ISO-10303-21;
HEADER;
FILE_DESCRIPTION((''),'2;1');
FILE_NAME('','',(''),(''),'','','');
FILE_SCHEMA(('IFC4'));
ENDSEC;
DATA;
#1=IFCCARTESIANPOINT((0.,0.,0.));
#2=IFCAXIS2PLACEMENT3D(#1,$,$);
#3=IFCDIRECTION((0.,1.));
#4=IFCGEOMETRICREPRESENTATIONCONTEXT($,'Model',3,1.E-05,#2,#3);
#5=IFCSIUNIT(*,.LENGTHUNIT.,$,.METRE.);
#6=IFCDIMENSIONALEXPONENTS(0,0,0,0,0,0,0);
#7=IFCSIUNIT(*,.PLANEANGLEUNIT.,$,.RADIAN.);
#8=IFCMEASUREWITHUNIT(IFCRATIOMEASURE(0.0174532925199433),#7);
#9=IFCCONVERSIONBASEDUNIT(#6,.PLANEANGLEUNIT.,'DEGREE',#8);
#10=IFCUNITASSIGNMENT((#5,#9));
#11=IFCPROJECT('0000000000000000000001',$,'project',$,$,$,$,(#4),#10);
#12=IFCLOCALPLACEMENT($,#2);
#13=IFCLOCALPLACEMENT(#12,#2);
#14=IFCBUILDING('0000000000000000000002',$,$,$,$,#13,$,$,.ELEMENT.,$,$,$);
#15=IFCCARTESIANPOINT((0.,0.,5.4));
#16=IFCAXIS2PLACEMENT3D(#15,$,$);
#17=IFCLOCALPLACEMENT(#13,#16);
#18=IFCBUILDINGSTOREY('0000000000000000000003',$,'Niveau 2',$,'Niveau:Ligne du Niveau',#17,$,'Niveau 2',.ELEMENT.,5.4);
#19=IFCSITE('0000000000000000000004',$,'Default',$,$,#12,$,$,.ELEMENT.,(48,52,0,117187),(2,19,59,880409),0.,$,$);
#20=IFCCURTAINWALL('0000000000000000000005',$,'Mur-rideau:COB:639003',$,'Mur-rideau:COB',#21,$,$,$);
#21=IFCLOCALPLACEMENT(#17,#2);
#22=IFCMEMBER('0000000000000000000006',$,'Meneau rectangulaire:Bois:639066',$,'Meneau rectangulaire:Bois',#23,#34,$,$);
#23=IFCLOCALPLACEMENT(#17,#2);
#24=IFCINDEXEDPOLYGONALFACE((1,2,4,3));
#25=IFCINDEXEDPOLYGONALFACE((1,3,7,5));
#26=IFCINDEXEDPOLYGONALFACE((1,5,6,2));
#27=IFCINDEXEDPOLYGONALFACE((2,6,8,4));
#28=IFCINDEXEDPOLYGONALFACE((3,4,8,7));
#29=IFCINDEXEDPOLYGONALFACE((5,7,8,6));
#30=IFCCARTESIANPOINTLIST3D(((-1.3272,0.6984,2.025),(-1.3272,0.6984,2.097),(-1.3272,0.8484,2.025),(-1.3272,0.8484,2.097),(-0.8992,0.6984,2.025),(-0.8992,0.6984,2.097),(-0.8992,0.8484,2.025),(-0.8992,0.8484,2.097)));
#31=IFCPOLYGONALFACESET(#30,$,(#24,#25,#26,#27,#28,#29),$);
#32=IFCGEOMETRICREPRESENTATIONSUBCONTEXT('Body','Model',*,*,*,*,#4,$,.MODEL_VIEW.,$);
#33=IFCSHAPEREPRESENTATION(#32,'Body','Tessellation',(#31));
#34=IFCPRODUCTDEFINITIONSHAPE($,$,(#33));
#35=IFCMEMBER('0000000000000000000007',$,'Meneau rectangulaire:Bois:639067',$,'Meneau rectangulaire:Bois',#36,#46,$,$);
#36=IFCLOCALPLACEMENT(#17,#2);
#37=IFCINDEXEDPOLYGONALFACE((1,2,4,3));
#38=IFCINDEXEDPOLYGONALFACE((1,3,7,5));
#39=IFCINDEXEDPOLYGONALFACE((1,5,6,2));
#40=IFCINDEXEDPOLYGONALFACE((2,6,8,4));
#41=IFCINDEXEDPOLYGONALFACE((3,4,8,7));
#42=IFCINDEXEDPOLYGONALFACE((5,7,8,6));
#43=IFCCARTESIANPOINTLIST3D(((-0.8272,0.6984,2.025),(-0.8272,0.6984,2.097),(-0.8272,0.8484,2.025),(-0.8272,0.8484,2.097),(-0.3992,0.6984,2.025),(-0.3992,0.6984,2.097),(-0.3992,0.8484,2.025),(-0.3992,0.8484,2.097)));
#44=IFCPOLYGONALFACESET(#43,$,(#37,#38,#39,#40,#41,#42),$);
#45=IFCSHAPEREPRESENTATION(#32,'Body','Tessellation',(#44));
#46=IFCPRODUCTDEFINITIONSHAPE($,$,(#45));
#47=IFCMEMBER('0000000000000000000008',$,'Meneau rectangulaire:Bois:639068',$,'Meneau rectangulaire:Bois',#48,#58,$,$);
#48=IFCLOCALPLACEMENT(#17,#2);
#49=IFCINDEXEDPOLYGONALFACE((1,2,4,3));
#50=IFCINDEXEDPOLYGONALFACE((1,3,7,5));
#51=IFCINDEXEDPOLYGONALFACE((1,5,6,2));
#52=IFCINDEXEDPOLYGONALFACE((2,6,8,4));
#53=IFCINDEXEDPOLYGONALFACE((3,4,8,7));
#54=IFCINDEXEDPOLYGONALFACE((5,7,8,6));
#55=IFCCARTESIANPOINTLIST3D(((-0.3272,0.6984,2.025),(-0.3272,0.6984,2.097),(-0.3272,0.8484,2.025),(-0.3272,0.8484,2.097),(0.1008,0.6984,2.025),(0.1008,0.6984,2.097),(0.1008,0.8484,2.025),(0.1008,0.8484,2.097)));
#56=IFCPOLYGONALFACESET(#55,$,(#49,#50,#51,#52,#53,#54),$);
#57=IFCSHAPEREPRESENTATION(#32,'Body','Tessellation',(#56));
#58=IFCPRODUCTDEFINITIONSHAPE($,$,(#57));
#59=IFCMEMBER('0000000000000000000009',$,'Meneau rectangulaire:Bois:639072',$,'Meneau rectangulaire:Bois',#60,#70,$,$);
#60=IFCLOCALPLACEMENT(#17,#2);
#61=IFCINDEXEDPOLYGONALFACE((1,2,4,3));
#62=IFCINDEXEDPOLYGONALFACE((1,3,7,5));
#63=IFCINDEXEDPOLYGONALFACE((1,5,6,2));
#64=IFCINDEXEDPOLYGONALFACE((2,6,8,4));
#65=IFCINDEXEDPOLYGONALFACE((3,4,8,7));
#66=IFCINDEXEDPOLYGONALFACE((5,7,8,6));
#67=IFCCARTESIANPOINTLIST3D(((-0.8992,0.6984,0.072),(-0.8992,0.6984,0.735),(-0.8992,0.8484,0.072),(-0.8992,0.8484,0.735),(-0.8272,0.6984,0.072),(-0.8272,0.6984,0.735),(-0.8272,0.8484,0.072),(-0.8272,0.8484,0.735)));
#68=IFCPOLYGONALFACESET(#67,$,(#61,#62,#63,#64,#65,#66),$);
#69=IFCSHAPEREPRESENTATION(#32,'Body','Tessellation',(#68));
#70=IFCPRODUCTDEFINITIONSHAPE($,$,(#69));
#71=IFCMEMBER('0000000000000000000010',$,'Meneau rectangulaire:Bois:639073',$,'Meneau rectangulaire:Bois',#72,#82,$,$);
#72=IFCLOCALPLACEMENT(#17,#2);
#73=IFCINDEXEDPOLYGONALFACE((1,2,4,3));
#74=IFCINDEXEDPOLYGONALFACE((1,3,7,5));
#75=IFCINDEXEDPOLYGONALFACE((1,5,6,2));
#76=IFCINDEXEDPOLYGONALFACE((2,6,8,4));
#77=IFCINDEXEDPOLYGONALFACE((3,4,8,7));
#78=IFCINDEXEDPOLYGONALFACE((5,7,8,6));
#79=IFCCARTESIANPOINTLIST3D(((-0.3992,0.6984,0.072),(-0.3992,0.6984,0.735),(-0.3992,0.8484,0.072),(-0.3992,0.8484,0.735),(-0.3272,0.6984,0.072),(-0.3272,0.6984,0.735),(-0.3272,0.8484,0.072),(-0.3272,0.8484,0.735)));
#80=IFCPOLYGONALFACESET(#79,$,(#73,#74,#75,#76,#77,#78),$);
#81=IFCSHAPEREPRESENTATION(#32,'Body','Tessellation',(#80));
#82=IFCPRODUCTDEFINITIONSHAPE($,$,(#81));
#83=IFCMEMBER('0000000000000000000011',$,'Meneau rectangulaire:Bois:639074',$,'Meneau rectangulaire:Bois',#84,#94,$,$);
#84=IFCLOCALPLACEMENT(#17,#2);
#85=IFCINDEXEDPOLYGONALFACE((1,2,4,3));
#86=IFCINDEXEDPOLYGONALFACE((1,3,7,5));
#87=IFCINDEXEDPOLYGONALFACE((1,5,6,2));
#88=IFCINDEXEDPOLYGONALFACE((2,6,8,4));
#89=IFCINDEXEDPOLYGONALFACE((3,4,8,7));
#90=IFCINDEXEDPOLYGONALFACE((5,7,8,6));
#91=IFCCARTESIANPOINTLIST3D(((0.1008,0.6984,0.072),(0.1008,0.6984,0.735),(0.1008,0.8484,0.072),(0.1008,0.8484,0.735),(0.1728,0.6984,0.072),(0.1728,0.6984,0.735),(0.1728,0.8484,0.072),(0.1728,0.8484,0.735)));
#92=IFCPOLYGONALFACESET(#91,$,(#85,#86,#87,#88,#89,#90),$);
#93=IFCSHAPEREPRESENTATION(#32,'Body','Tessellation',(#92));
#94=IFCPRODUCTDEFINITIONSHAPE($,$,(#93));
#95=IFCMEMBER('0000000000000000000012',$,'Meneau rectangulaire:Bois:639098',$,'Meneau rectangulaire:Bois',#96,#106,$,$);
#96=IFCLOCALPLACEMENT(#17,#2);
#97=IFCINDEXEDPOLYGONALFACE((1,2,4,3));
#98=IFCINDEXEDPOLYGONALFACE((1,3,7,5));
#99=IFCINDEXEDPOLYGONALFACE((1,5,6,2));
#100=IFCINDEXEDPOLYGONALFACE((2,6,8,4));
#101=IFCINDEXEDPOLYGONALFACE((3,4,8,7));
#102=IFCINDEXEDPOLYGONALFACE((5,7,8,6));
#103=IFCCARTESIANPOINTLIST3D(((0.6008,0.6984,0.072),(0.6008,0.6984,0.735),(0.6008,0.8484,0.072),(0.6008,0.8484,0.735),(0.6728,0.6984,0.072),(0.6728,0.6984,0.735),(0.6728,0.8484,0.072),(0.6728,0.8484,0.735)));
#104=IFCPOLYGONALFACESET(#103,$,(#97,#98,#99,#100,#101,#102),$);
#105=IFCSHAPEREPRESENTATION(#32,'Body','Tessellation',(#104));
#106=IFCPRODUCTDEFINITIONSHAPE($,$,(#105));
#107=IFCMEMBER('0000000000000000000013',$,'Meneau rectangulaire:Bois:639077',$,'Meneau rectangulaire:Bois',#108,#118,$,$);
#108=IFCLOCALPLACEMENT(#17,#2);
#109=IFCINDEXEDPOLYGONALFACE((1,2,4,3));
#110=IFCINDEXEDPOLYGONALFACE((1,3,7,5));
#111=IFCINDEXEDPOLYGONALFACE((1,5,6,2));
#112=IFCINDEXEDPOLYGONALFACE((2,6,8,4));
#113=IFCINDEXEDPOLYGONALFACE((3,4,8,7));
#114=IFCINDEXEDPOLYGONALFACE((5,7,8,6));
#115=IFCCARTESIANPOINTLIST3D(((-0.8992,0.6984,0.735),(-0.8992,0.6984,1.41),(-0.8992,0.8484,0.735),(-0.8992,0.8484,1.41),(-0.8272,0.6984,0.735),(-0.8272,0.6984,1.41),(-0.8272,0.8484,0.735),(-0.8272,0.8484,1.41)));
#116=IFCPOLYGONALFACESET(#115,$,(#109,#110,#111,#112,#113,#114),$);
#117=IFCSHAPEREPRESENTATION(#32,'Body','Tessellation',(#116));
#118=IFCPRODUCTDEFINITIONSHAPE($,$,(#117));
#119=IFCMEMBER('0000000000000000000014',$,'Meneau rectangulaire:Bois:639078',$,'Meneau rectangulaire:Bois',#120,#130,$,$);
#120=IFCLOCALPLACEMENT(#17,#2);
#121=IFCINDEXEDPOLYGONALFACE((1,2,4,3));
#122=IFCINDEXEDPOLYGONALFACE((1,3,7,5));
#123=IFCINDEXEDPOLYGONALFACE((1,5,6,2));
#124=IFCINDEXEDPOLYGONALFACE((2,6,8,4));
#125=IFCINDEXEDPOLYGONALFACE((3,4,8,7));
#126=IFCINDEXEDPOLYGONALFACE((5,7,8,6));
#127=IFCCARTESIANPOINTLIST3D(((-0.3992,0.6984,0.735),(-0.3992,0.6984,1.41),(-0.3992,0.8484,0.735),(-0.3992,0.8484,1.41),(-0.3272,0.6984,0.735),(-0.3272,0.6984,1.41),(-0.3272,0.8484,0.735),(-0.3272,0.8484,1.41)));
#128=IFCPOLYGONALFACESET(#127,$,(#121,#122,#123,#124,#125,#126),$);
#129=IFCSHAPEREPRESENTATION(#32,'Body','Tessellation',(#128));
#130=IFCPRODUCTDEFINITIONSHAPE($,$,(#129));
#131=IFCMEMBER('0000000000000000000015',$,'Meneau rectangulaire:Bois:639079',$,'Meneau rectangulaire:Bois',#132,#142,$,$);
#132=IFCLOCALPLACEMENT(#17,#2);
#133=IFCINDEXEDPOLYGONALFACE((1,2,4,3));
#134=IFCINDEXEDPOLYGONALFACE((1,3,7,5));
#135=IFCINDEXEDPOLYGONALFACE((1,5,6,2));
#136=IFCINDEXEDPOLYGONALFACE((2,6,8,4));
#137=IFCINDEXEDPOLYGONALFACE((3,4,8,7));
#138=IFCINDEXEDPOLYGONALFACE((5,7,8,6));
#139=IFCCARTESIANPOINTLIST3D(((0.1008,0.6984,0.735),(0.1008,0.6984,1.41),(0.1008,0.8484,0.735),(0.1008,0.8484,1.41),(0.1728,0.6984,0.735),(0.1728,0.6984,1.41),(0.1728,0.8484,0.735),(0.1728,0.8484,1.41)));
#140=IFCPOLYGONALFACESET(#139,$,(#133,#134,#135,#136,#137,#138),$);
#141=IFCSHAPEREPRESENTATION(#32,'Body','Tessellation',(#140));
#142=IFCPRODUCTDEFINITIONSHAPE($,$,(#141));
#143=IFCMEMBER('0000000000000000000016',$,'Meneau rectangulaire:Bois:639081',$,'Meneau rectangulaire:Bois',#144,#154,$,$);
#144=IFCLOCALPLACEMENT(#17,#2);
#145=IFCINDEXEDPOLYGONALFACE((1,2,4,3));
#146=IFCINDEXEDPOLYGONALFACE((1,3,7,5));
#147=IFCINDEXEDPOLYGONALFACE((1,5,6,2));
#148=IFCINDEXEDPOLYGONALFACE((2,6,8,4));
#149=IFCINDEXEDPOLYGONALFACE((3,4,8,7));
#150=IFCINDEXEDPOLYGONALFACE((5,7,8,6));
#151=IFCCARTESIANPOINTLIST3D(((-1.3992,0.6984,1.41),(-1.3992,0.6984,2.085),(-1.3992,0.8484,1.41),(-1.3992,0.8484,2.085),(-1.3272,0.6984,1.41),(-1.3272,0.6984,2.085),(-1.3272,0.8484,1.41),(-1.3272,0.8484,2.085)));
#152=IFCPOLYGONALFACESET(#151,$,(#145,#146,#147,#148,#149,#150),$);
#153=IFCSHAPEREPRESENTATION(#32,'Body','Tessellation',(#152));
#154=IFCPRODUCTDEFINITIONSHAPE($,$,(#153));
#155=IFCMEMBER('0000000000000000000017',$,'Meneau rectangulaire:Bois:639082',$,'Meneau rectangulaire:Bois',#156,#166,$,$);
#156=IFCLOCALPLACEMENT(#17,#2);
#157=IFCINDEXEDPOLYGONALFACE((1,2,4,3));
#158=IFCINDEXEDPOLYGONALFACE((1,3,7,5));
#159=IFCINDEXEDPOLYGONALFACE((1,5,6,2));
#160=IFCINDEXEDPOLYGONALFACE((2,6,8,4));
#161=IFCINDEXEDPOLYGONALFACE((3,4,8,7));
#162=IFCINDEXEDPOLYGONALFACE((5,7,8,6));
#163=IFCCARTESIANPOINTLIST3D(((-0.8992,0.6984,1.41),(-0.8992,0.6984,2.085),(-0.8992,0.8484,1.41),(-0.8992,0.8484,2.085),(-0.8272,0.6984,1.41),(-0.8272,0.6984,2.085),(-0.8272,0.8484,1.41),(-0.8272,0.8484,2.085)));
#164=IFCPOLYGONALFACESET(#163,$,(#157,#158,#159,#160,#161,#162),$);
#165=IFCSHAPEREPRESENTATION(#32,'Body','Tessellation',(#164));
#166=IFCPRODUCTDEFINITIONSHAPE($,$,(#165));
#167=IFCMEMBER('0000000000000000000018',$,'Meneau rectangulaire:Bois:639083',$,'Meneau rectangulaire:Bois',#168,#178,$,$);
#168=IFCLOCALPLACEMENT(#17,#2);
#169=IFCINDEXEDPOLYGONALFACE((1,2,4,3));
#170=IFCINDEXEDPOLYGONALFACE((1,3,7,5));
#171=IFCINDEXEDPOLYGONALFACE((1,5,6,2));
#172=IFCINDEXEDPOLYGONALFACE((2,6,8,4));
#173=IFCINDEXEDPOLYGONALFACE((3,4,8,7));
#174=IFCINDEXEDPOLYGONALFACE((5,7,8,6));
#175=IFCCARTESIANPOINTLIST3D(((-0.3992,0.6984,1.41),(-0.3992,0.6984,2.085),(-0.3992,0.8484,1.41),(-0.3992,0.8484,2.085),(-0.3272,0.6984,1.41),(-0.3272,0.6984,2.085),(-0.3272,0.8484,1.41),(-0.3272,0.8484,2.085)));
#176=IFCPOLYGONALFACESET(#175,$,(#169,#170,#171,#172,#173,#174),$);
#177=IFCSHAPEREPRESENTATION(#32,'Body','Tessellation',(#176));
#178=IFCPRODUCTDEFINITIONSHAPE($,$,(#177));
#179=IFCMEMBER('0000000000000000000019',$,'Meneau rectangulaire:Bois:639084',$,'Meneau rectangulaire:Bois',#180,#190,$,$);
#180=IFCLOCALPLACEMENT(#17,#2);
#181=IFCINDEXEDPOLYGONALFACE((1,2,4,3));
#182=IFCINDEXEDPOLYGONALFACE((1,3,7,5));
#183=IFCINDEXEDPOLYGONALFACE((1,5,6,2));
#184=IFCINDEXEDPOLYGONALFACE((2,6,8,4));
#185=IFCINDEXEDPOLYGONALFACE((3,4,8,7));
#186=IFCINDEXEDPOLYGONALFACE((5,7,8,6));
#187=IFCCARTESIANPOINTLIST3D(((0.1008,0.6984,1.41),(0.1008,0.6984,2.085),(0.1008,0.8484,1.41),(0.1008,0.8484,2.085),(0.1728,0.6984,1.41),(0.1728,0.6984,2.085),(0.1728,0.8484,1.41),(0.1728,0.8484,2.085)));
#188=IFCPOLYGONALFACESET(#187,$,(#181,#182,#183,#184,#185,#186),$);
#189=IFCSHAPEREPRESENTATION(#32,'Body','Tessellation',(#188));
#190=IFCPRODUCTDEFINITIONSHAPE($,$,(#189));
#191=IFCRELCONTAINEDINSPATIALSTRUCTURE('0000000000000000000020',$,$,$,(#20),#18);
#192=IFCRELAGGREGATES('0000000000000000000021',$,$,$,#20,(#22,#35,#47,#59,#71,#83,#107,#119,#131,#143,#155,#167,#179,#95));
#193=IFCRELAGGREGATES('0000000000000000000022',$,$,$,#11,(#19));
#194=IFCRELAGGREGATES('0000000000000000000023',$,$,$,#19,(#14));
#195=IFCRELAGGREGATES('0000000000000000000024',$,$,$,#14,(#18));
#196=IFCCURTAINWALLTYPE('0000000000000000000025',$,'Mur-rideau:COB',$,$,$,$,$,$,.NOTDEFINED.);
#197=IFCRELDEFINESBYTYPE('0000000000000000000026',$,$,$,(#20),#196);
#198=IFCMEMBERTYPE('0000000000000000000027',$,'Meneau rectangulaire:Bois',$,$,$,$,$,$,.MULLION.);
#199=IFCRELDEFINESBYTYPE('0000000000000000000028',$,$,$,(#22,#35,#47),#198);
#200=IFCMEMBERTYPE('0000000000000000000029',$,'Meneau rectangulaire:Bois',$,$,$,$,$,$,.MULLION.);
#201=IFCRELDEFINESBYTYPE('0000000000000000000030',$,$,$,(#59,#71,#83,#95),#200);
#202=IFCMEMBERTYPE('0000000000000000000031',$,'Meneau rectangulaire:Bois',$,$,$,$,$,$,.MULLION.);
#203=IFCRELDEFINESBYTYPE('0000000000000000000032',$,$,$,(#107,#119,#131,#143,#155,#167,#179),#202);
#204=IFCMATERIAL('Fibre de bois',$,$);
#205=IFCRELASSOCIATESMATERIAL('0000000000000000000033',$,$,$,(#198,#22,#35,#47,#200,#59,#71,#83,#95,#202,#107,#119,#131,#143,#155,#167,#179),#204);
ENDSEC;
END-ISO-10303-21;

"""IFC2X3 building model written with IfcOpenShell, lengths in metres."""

from ifc_helpers import new_model, entity, si_unit, converted_unit, direction, frame, origin, origin_2d_with_axis, place, context, subcontext, project, spatial, rectangle, extrude, source, transform, mapped, material, type_object, type_shapes, element, aggregate, save


model = new_model("IFC2X3")

# Units and contexts
model_context = context("Model", 3, precision=1e-05, world=origin(), true_north=direction((0.0, 1.0)))
body_context = subcontext(model_context, "Body", "Model", "MODEL_VIEW")
ifc_project = project(units=[si_unit("LENGTHUNIT", "METRE"), converted_unit("PLANEANGLEUNIT", "DEGREE", entity("IfcRatioMeasure", 0.0174532925199433), si_unit("PLANEANGLEUNIT", "RADIAN"), dimensions=[0, 0, 0, 0, 0, 0, 0])], contexts=[model_context])

# Site, building, storey
site_placement = place(None, origin())
site = spatial("IfcSite", under=ifc_project, at=site_placement, Name="Default", CompositionType="ELEMENT", RefLatitude=(48, 52, 0, 117187), RefLongitude=(2, 19, 59, 880409), RefElevation=0.0)
building_placement = place(site_placement, origin())
building = spatial("IfcBuilding", under=site, at=building_placement, CompositionType="ELEMENT")
storey_placement = place(building_placement, frame((0.0, 0.0, 5.4)))
storey = spatial("IfcBuildingStorey", under=building, at=storey_placement, Name="Niveau 2", ObjectType="Niveau:Ligne du Niveau", LongName="Niveau 2", CompositionType="ELEMENT", Elevation=5.4)

# Curtain wall, members
curtain_wall_type_1 = type_object("IfcCurtainWallType", Name="Mur-rideau:COB", PredefinedType="NOTDEFINED")
curtain_wall_1_placement = place(storey_placement, frame((0.0, 0.0, -5.4)))
curtain_wall_1 = element("IfcCurtainWall", 1, at=curtain_wall_1_placement, inside=storey, type_object=curtain_wall_type_1, Name="Mur-rideau:COB:639003", ObjectType="Mur-rideau:COB")
ifc_material_1 = material(Name="Fibre de bois")
member_type_1 = type_object("IfcMemberType", Name="Meneau rectangulaire:Bois", PredefinedType="MULLION", material=ifc_material_1)
shared_shape_1 = source(origin(), body_context, "Body", "SweptSolid", [
    extrude(rectangle(XDim=0.15, YDim=0.072, at=origin_2d_with_axis()), frame((-0.024, 0.0, -0.428), z_axis=(0.0, 0.0, 1.0), x_axis=(0.0, -1.0, 0.0)), (0.0, 0.0, 1.0), 0.428),
])
type_shapes(member_type_1, [shared_shape_1])
member_1_placement = place(storey_placement, frame((-0.8992, 0.7734, 2.085), z_axis=(1.0, 0.0, 0.0), x_axis=(0.0, 0.0, 1.0)))
member_1 = element("IfcMember", 2, at=member_1_placement, type_object=member_type_1, material=ifc_material_1, Name="Meneau rectangulaire:Bois:639066", ObjectType="Meneau rectangulaire:Bois", context=body_context, shape_type="MappedRepresentation", body=[
    mapped(shared_shape_1, transform((0.0, 0.0, 0.0), scale=1.0)),
])
member_2_placement = place(storey_placement, frame((-0.3992, 0.7734, 2.085), z_axis=(1.0, 0.0, 0.0), x_axis=(0.0, 0.0, 1.0)))
member_2 = element("IfcMember", 3, at=member_2_placement, type_object=member_type_1, material=ifc_material_1, Name="Meneau rectangulaire:Bois:639067", ObjectType="Meneau rectangulaire:Bois", context=body_context, shape_type="MappedRepresentation", body=[
    mapped(shared_shape_1, transform((0.0, 0.0, 0.0), scale=1.0)),
])
member_3_placement = place(storey_placement, frame((0.1008, 0.7734, 2.085), z_axis=(1.0, 0.0, 0.0), x_axis=(0.0, 0.0, 1.0)))
member_3 = element("IfcMember", 4, at=member_3_placement, type_object=member_type_1, material=ifc_material_1, Name="Meneau rectangulaire:Bois:639068", ObjectType="Meneau rectangulaire:Bois", context=body_context, shape_type="MappedRepresentation", body=[
    mapped(shared_shape_1, transform((0.0, 0.0, 0.0), scale=1.0)),
])
member_type_2 = type_object("IfcMemberType", Name="Meneau rectangulaire:Bois", PredefinedType="MULLION", material=ifc_material_1)
shared_shape_2 = source(origin(), body_context, "Body", "SweptSolid", [
    extrude(rectangle(XDim=0.15, YDim=0.072, at=origin_2d_with_axis()), frame((-0.024, 0.0, -0.663), z_axis=(0.0, 0.0, 1.0), x_axis=(0.0, -1.0, 0.0)), (0.0, 0.0, 1.0), 0.663),
])
type_shapes(member_type_2, [shared_shape_2])
member_4_placement = place(storey_placement, frame((-0.8392, 0.7734, 0.072), z_axis=(0.0, 0.0, -1.0), x_axis=(1.0, 0.0, 0.0)))
member_4 = element("IfcMember", 5, at=member_4_placement, type_object=member_type_2, material=ifc_material_1, Name="Meneau rectangulaire:Bois:639072", ObjectType="Meneau rectangulaire:Bois", context=body_context, shape_type="MappedRepresentation", body=[
    mapped(shared_shape_2, transform((0.0, 0.0, 0.0), scale=1.0)),
])
member_5_placement = place(storey_placement, frame((-0.3392, 0.7734, 0.072), z_axis=(0.0, 0.0, -1.0), x_axis=(1.0, 0.0, 0.0)))
member_5 = element("IfcMember", 6, at=member_5_placement, type_object=member_type_2, material=ifc_material_1, Name="Meneau rectangulaire:Bois:639073", ObjectType="Meneau rectangulaire:Bois", context=body_context, shape_type="MappedRepresentation", body=[
    mapped(shared_shape_2, transform((0.0, 0.0, 0.0), scale=1.0)),
])
member_6_placement = place(storey_placement, frame((0.1608, 0.7734, 0.072), z_axis=(0.0, 0.0, -1.0), x_axis=(1.0, 0.0, 0.0)))
member_6 = element("IfcMember", 7, at=member_6_placement, type_object=member_type_2, material=ifc_material_1, Name="Meneau rectangulaire:Bois:639074", ObjectType="Meneau rectangulaire:Bois", context=body_context, shape_type="MappedRepresentation", body=[
    mapped(shared_shape_2, transform((0.0, 0.0, 0.0), scale=1.0)),
])
member_7_placement = place(storey_placement, frame((0.6608, 0.7734, 0.072), z_axis=(0.0, 0.0, -1.0), x_axis=(1.0, 0.0, 0.0)))
member_7 = element("IfcMember", 8, at=member_7_placement, type_object=member_type_2, material=ifc_material_1, Name="Meneau rectangulaire:Bois:639098", ObjectType="Meneau rectangulaire:Bois", context=body_context, shape_type="MappedRepresentation", body=[
    mapped(shared_shape_2, transform((0.0, 0.0, 0.0), scale=1.0)),
])
member_type_3 = type_object("IfcMemberType", Name="Meneau rectangulaire:Bois", PredefinedType="MULLION", material=ifc_material_1)
shared_shape_3 = source(origin(), body_context, "Body", "SweptSolid", [
    extrude(rectangle(XDim=0.15, YDim=0.072, at=origin_2d_with_axis()), frame((-0.024, 0.0, -0.675), z_axis=(0.0, 0.0, 1.0), x_axis=(0.0, -1.0, 0.0)), (0.0, 0.0, 1.0), 0.675),
])
type_shapes(member_type_3, [shared_shape_3])
member_8_placement = place(storey_placement, frame((-0.8392, 0.7734, 0.735), z_axis=(0.0, 0.0, -1.0), x_axis=(1.0, 0.0, 0.0)))
member_8 = element("IfcMember", 9, at=member_8_placement, type_object=member_type_3, material=ifc_material_1, Name="Meneau rectangulaire:Bois:639077", ObjectType="Meneau rectangulaire:Bois", context=body_context, shape_type="MappedRepresentation", body=[
    mapped(shared_shape_3, transform((0.0, 0.0, 0.0), scale=1.0)),
])
member_9_placement = place(storey_placement, frame((-0.3392, 0.7734, 0.735), z_axis=(0.0, 0.0, -1.0), x_axis=(1.0, 0.0, 0.0)))
member_9 = element("IfcMember", 10, at=member_9_placement, type_object=member_type_3, material=ifc_material_1, Name="Meneau rectangulaire:Bois:639078", ObjectType="Meneau rectangulaire:Bois", context=body_context, shape_type="MappedRepresentation", body=[
    mapped(shared_shape_3, transform((0.0, 0.0, 0.0), scale=1.0)),
])
member_10_placement = place(storey_placement, frame((0.1608, 0.7734, 0.735), z_axis=(0.0, 0.0, -1.0), x_axis=(1.0, 0.0, 0.0)))
member_10 = element("IfcMember", 11, at=member_10_placement, type_object=member_type_3, material=ifc_material_1, Name="Meneau rectangulaire:Bois:639079", ObjectType="Meneau rectangulaire:Bois", context=body_context, shape_type="MappedRepresentation", body=[
    mapped(shared_shape_3, transform((0.0, 0.0, 0.0), scale=1.0)),
])
member_11_placement = place(storey_placement, frame((-1.3392, 0.7734, 1.41), z_axis=(0.0, 0.0, -1.0), x_axis=(1.0, 0.0, 0.0)))
member_11 = element("IfcMember", 12, at=member_11_placement, type_object=member_type_3, material=ifc_material_1, Name="Meneau rectangulaire:Bois:639081", ObjectType="Meneau rectangulaire:Bois", context=body_context, shape_type="MappedRepresentation", body=[
    mapped(shared_shape_3, transform((0.0, 0.0, 0.0), scale=1.0)),
])
member_12_placement = place(storey_placement, frame((-0.8392, 0.7734, 1.41), z_axis=(0.0, 0.0, -1.0), x_axis=(1.0, 0.0, 0.0)))
member_12 = element("IfcMember", 13, at=member_12_placement, type_object=member_type_3, material=ifc_material_1, Name="Meneau rectangulaire:Bois:639082", ObjectType="Meneau rectangulaire:Bois", context=body_context, shape_type="MappedRepresentation", body=[
    mapped(shared_shape_3, transform((0.0, 0.0, 0.0), scale=1.0)),
])
member_13_placement = place(storey_placement, frame((-0.3392, 0.7734, 1.41), z_axis=(0.0, 0.0, -1.0), x_axis=(1.0, 0.0, 0.0)))
member_13 = element("IfcMember", 14, at=member_13_placement, type_object=member_type_3, material=ifc_material_1, Name="Meneau rectangulaire:Bois:639083", ObjectType="Meneau rectangulaire:Bois", context=body_context, shape_type="MappedRepresentation", body=[
    mapped(shared_shape_3, transform((0.0, 0.0, 0.0), scale=1.0)),
])
member_14_placement = place(storey_placement, frame((0.1608, 0.7734, 1.41), z_axis=(0.0, 0.0, -1.0), x_axis=(1.0, 0.0, 0.0)))
member_14 = element("IfcMember", 15, at=member_14_placement, type_object=member_type_3, material=ifc_material_1, Name="Meneau rectangulaire:Bois:639084", ObjectType="Meneau rectangulaire:Bois", context=body_context, shape_type="MappedRepresentation", body=[
    mapped(shared_shape_3, transform((0.0, 0.0, 0.0), scale=1.0)),
])
aggregate(curtain_wall_1, [member_1, member_2, member_3, member_4, member_5, member_6, member_8, member_9, member_10, member_11, member_12, member_13, member_14, member_7])

save(model, "model.ifc")
